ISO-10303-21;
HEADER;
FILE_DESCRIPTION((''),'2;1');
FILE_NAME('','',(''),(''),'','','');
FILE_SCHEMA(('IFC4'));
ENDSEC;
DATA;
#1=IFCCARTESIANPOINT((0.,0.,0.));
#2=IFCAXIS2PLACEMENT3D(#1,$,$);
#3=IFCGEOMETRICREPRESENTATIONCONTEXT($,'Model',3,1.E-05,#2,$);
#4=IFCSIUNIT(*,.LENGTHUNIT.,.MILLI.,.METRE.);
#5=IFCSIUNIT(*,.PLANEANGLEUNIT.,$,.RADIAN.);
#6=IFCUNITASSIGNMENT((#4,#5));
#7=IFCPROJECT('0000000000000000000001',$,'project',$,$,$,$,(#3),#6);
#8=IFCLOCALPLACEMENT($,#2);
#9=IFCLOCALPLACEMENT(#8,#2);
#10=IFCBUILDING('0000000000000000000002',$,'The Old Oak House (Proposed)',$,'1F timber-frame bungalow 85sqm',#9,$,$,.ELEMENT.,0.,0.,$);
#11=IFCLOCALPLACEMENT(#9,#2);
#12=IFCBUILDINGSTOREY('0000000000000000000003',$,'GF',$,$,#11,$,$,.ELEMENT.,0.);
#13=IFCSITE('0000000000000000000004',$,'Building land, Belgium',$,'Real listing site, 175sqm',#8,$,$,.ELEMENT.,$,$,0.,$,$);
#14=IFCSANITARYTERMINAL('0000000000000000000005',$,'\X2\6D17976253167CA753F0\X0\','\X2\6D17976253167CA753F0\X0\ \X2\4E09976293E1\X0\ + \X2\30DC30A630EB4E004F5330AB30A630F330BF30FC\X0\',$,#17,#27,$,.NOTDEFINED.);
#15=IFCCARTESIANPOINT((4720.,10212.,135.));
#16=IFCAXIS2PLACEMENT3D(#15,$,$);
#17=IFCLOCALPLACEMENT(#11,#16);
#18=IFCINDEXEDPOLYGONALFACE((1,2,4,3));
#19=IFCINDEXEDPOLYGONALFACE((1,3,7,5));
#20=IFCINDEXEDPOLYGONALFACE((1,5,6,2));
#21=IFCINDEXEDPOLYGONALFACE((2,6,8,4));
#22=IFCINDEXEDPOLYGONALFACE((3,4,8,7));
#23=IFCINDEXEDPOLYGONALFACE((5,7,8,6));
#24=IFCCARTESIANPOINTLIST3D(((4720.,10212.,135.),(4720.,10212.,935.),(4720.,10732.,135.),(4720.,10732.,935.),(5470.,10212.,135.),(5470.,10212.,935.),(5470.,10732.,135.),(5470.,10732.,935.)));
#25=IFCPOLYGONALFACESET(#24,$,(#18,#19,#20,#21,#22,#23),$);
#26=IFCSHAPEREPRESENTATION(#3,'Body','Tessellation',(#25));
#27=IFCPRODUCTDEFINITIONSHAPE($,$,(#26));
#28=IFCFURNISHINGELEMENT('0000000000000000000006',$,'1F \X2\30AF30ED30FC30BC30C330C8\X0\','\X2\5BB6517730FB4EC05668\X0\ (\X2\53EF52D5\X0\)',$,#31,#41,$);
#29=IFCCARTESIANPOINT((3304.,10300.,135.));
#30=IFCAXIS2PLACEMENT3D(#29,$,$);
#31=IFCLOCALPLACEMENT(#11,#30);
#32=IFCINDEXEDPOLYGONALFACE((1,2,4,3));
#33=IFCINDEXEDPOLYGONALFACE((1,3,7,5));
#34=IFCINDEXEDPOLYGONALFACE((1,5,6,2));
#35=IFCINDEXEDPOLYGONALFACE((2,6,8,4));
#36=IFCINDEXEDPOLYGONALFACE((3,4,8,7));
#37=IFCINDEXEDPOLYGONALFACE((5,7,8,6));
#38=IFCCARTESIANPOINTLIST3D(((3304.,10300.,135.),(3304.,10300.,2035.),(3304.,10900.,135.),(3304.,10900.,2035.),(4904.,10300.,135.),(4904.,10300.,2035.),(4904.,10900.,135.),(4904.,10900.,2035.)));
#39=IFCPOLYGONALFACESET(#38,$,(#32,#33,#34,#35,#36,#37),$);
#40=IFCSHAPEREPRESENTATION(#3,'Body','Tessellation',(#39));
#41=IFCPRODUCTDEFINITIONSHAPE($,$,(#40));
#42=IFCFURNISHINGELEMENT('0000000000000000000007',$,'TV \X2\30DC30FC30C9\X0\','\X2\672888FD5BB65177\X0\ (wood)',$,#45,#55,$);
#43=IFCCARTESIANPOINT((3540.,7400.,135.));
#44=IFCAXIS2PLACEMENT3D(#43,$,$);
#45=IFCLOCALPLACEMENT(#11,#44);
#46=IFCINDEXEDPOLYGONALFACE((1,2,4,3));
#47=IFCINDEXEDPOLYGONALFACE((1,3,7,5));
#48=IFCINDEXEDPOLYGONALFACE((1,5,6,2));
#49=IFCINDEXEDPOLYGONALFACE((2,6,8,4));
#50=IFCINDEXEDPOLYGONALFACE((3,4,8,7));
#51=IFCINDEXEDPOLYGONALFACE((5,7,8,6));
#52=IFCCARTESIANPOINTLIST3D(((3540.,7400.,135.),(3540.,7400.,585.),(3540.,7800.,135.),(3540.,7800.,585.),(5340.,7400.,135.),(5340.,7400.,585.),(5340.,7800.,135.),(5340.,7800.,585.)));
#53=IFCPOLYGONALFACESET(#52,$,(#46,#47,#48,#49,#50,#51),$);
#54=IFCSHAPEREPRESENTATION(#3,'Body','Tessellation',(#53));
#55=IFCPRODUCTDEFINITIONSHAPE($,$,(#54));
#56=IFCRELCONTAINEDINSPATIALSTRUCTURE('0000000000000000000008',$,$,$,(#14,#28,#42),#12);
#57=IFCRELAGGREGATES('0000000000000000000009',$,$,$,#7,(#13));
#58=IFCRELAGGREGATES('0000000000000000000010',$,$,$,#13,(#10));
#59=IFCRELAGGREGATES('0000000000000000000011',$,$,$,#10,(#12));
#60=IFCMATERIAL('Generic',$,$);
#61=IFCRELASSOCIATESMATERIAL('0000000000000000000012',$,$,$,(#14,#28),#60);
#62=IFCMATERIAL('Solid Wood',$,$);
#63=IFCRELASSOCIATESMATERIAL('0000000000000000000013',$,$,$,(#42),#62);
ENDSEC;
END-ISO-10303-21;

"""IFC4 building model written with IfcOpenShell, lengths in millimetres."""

from ifc_helpers import new_model, si_unit, frame, frame_2d, origin, place, context, project, spatial, rectangle, extrude, material, element, save


model = new_model("IFC4")

# Units and contexts
model_context = context("Model", 3, precision=1e-05, world=origin())
ifc_project = project(units=[si_unit("LENGTHUNIT", "METRE", prefix="MILLI"), si_unit("PLANEANGLEUNIT", "RADIAN")], contexts=[model_context])

# Site, building, storey
site_placement = place(None, origin())
site = spatial("IfcSite", under=ifc_project, at=site_placement, Name="Building land, Belgium", ObjectType="Real listing site, 175sqm", CompositionType="ELEMENT", RefElevation=0.0)
building_placement = place(site_placement, origin())
building = spatial("IfcBuilding", under=site, at=building_placement, Name="The Old Oak House (Proposed)", ObjectType="1F timber-frame bungalow 85sqm", CompositionType="ELEMENT", ElevationOfRefHeight=0.0, ElevationOfTerrain=0.0)
storey_placement = place(building_placement, origin())
storey = spatial("IfcBuildingStorey", under=building, at=storey_placement, Name="GF", CompositionType="ELEMENT", Elevation=0.0)

# Shared definitions
ifc_material_1 = material(Name="Solid Wood")

# Shared definitions
ifc_material_2 = material(Name="Generic")

# Sanitary terminal
sanitary_terminal_1_placement = place(storey_placement, frame((4720.0, 10212.0, 135.0)))
element("IfcSanitaryTerminal", 1, at=sanitary_terminal_1_placement, inside=storey, material=ifc_material_2, Name="洗面化粧台", Description="洗面化粧台 三面鏡 + ボウル一体カウンター", PredefinedType="NOTDEFINED", context=model_context, shape_type="SweptSolid", body=[
    extrude(rectangle(XDim=750.0, YDim=520.0, at=frame_2d((375.0, 260.0))), frame((4720.0, 10212.0, 135.0)), (0.0, 0.0, 1.0), 800.0),
])

# Furnishing elements
furnishing_1_placement = place(storey_placement, frame((3304.0, 10300.0, 135.0)))
element("IfcFurnishingElement", 2, at=furnishing_1_placement, inside=storey, material=ifc_material_2, Name="1F クローゼット", Description="家具・什器 (可動)", context=model_context, shape_type="SweptSolid", body=[
    extrude(rectangle(XDim=1600.0, YDim=600.0, at=frame_2d((800.0, 300.0))), frame((3304.0, 10300.0, 135.0)), (0.0, 0.0, 1.0), 1900.0),
])
furnishing_2_placement = place(storey_placement, frame((3540.0, 7400.0, 135.0)))
element("IfcFurnishingElement", 3, at=furnishing_2_placement, inside=storey, material=ifc_material_1, Name="TV ボード", Description="木製家具 (wood)", context=model_context, shape_type="SweptSolid", body=[
    extrude(rectangle(XDim=1800.0, YDim=400.0, at=frame_2d((900.0, 200.0))), frame((3540.0, 7400.0, 135.0)), (0.0, 0.0, 1.0), 450.0),
])

save(model, "model.ifc")
